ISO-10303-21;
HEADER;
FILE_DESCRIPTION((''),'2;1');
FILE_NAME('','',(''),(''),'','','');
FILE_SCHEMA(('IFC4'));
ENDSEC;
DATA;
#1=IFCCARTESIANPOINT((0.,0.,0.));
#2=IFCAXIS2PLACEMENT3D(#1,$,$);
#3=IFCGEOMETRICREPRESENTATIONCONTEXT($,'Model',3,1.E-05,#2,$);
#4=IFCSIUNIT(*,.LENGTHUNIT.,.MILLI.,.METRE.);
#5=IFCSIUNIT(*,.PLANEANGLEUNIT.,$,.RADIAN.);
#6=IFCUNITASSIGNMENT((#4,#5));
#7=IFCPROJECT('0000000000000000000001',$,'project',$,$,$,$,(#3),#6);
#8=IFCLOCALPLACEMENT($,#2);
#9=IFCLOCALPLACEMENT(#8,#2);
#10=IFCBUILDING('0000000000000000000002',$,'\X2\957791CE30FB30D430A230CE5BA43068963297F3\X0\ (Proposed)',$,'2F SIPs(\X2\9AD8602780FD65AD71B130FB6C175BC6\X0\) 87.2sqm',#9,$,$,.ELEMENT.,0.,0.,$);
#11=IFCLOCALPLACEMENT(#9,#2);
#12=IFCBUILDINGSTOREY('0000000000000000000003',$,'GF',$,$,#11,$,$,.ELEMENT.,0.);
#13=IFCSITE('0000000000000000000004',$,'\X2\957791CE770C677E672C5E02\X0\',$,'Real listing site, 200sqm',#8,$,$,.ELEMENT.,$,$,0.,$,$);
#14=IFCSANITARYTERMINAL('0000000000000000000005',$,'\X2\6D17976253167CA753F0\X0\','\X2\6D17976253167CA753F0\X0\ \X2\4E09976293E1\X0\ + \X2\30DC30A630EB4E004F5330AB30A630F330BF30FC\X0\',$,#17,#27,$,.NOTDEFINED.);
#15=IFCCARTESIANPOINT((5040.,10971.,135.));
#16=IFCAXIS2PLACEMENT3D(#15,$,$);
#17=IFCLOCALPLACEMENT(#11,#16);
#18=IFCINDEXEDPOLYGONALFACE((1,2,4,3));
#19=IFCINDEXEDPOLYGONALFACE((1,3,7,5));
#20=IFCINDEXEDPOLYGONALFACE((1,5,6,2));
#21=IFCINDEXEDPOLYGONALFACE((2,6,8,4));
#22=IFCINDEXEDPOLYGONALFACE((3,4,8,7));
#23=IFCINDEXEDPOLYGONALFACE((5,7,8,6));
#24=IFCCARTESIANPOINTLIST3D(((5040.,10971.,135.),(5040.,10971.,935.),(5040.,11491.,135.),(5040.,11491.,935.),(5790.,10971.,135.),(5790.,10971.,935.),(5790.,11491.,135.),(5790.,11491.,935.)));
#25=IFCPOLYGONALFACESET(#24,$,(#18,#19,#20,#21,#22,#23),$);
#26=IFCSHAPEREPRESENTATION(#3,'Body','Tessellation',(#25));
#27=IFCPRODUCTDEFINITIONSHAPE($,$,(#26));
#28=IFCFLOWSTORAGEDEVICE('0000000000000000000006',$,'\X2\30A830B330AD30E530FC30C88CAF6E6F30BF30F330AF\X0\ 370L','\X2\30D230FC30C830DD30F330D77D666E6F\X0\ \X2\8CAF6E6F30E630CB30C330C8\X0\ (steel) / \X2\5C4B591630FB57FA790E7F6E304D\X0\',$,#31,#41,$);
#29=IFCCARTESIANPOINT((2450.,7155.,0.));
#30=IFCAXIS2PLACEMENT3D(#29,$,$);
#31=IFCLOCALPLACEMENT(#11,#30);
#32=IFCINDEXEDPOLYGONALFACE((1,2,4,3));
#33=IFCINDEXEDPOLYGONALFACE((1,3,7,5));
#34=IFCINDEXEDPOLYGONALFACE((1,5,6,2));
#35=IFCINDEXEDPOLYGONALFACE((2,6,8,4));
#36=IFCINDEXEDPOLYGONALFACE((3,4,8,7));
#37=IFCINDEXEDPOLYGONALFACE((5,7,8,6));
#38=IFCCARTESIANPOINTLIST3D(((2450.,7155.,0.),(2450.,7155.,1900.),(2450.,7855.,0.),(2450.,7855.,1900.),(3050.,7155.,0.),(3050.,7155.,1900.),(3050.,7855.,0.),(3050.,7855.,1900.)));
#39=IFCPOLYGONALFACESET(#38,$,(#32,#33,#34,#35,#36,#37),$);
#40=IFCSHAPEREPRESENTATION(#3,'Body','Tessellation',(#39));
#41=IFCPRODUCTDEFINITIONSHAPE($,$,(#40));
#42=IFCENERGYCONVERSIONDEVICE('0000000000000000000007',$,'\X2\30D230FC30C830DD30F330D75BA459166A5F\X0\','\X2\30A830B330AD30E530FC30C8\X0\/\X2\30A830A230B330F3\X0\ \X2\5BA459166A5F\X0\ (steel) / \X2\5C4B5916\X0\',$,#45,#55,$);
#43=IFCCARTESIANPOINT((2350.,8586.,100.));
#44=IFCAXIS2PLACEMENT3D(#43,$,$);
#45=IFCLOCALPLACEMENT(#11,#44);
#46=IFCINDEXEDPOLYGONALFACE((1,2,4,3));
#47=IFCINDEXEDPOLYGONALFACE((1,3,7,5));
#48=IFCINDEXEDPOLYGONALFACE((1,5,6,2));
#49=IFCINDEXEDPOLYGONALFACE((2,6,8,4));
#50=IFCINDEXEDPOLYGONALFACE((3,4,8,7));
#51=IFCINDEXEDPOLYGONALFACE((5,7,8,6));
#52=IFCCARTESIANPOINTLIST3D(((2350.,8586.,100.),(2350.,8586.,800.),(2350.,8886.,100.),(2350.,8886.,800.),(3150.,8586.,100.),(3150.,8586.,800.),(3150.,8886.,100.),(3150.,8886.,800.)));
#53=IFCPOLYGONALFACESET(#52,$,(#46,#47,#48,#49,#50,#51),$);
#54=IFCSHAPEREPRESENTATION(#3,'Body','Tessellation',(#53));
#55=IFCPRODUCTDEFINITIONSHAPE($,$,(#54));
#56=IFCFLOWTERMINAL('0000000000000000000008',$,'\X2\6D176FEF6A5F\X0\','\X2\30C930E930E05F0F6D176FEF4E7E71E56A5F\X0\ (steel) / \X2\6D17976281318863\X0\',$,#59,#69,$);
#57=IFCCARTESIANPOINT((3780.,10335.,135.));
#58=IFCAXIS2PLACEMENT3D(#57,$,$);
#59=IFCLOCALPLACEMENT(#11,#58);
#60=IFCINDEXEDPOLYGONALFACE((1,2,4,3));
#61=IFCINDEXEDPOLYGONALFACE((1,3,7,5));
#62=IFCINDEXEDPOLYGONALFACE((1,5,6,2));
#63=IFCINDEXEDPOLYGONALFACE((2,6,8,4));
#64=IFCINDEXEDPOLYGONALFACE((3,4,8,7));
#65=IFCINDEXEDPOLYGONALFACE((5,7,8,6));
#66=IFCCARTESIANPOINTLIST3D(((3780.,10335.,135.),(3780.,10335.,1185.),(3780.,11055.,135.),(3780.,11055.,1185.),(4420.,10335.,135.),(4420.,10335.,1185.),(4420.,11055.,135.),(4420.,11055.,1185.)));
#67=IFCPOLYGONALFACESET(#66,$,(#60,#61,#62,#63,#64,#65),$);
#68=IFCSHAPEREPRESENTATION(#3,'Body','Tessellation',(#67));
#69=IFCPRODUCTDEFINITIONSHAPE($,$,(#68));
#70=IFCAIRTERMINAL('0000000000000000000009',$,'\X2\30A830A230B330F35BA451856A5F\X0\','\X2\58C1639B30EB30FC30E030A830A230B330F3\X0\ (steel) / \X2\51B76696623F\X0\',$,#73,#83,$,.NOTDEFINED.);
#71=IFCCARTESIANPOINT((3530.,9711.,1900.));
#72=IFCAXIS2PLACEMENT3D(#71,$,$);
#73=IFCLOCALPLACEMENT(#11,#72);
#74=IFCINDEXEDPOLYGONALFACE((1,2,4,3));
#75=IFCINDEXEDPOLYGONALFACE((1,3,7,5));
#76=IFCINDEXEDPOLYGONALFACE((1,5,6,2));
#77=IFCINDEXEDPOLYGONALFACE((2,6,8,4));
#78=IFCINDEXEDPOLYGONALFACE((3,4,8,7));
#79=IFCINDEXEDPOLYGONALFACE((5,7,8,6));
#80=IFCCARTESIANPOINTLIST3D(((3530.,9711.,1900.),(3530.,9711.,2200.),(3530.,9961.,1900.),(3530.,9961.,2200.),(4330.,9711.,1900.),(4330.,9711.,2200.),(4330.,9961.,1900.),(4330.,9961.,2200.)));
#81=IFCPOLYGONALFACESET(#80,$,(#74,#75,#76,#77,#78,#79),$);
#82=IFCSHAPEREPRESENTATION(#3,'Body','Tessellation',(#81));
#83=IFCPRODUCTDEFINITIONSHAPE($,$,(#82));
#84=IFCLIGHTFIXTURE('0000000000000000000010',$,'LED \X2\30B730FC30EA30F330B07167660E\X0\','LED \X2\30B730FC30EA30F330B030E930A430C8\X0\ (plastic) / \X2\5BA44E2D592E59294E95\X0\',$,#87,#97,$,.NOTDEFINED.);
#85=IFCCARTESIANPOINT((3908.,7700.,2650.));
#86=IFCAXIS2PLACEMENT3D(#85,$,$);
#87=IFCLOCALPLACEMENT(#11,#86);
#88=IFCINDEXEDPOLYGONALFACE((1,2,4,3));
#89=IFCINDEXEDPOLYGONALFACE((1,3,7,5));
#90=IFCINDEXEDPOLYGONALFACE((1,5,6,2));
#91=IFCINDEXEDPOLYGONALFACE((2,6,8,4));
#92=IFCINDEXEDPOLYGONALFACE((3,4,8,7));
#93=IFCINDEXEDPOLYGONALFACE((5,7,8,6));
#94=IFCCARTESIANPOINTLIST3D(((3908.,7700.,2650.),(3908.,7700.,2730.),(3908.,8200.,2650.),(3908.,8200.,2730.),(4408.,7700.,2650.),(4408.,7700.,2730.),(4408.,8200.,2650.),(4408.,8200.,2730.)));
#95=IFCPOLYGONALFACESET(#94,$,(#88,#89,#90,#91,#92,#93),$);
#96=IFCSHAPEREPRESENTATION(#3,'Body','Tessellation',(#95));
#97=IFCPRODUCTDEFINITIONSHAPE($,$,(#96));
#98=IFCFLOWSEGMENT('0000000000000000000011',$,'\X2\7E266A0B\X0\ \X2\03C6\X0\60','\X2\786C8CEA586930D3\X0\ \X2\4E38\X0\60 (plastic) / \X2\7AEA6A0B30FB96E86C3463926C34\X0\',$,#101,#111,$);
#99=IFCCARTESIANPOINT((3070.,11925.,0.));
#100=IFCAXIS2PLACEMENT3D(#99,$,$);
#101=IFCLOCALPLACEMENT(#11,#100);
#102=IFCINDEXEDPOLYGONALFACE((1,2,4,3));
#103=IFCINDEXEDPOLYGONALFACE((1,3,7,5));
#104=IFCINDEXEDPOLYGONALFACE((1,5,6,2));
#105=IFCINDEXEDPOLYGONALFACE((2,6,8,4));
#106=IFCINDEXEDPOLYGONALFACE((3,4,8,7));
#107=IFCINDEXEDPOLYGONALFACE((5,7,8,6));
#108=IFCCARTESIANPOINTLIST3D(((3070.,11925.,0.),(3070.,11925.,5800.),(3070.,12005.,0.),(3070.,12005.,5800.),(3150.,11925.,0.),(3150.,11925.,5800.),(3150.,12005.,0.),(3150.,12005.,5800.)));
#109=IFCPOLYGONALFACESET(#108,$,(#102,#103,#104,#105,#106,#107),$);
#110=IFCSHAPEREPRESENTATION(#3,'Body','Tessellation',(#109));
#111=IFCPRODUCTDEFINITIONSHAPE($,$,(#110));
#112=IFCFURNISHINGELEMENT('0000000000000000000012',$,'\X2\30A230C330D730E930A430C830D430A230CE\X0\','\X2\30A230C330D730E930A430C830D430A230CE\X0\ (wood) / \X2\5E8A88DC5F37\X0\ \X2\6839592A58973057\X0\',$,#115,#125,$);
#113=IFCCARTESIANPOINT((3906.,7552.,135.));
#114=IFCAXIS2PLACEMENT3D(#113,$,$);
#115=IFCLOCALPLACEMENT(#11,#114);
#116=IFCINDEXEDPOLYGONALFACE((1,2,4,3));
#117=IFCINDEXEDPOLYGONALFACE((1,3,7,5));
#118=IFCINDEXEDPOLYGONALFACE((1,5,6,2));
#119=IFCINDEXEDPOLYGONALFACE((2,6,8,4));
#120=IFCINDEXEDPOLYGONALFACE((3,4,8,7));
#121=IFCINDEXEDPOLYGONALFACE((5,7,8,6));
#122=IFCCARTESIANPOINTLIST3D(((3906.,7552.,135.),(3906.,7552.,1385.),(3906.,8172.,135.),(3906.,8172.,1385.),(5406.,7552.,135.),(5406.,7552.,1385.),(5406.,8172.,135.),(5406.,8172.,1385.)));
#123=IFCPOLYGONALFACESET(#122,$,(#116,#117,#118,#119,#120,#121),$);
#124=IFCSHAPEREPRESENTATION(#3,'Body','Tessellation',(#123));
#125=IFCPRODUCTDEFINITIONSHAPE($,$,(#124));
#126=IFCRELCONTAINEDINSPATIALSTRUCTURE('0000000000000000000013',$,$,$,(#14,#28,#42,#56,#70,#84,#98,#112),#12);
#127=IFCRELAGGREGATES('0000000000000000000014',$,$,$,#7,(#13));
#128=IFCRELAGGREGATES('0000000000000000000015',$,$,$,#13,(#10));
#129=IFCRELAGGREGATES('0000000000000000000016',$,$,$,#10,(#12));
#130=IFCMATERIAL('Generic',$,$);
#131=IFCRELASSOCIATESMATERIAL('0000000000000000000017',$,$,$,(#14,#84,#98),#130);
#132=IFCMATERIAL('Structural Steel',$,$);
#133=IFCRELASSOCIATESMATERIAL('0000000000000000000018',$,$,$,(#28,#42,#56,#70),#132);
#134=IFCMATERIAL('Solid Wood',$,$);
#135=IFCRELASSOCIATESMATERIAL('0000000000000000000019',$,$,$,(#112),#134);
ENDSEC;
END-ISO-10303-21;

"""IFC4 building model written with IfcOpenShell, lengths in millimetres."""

from ifc_helpers import new_model, si_unit, frame, frame_2d, origin, place, context, project, spatial, rectangle, extrude, material, element, save


model = new_model("IFC4")

# Units and contexts
model_context = context("Model", 3, precision=1e-05, world=origin())
ifc_project = project(units=[si_unit("LENGTHUNIT", "METRE", prefix="MILLI"), si_unit("PLANEANGLEUNIT", "RADIAN")], contexts=[model_context])

# Site, building, storey
site_placement = place(None, origin())
site = spatial("IfcSite", under=ifc_project, at=site_placement, Name="長野県松本市", ObjectType="Real listing site, 200sqm", CompositionType="ELEMENT", RefElevation=0.0)
building_placement = place(site_placement, origin())
building = spatial("IfcBuilding", under=site, at=building_placement, Name="長野・ピアノ室と防音 (Proposed)", ObjectType="2F SIPs(高性能断熱・気密) 87.2sqm", CompositionType="ELEMENT", ElevationOfRefHeight=0.0, ElevationOfTerrain=0.0)
storey_placement = place(building_placement, origin())
storey = spatial("IfcBuildingStorey", under=building, at=storey_placement, Name="GF", CompositionType="ELEMENT", Elevation=0.0)

# Shared definitions
ifc_material_1 = material(Name="Solid Wood")

# Shared definitions
ifc_material_2 = material(Name="Generic")

# Sanitary terminal
sanitary_terminal_1_placement = place(storey_placement, frame((5040.0, 10971.0, 135.0)))
element("IfcSanitaryTerminal", 1, at=sanitary_terminal_1_placement, inside=storey, material=ifc_material_2, Name="洗面化粧台", Description="洗面化粧台 三面鏡 + ボウル一体カウンター", PredefinedType="NOTDEFINED", context=model_context, shape_type="SweptSolid", body=[
    extrude(rectangle(XDim=750.0, YDim=520.0, at=frame_2d((375.0, 260.0))), frame((5040.0, 10971.0, 135.0)), (0.0, 0.0, 1.0), 800.0),
])

# Flow storage device
ifc_material_3 = material(Name="Structural Steel")
flow_storage_device_placement = place(storey_placement, frame((2450.0, 7155.0, 0.0)))
element("IfcFlowStorageDevice", 2, at=flow_storage_device_placement, inside=storey, material=ifc_material_3, Name="エコキュート貯湯タンク 370L", Description="ヒートポンプ給湯 貯湯ユニット (steel) / 屋外・基礎置き", context=model_context, shape_type="SweptSolid", body=[
    extrude(rectangle(XDim=600.0, YDim=700.0, at=frame_2d((300.0, 350.0))), frame((2450.0, 7155.0, 0.0)), (0.0, 0.0, 1.0), 1900.0),
])

# Energy conversion device
energy_conversion_device_placement = place(storey_placement, frame((2350.0, 8586.0, 100.0)))
element("IfcEnergyConversionDevice", 3, at=energy_conversion_device_placement, inside=storey, material=ifc_material_3, Name="ヒートポンプ室外機", Description="エコキュート/エアコン 室外機 (steel) / 屋外", context=model_context, shape_type="SweptSolid", body=[
    extrude(rectangle(XDim=800.0, YDim=300.0, at=frame_2d((400.0, 150.0))), frame((2350.0, 8586.0, 100.0)), (0.0, 0.0, 1.0), 700.0),
])

# Flow terminal
flow_terminal_placement = place(storey_placement, frame((3780.0, 10335.0, 135.0)))
element("IfcFlowTerminal", 4, at=flow_terminal_placement, inside=storey, material=ifc_material_3, Name="洗濯機", Description="ドラム式洗濯乾燥機 (steel) / 洗面脱衣", context=model_context, shape_type="SweptSolid", body=[
    extrude(rectangle(XDim=640.0, YDim=720.0, at=frame_2d((320.0, 360.0))), frame((3780.0, 10335.0, 135.0)), (0.0, 0.0, 1.0), 1050.0),
])

# Air terminal
air_terminal_placement = place(storey_placement, frame((3530.0, 9711.0, 1900.0)))
element("IfcAirTerminal", 5, at=air_terminal_placement, inside=storey, material=ifc_material_3, Name="エアコン室内機", Description="壁掛ルームエアコン (steel) / 冷暖房", PredefinedType="NOTDEFINED", context=model_context, shape_type="SweptSolid", body=[
    extrude(rectangle(XDim=800.0, YDim=250.0, at=frame_2d((400.0, 125.0))), frame((3530.0, 9711.0, 1900.0)), (0.0, 0.0, 1.0), 300.0),
])

# Light fixture
light_fixture_placement = place(storey_placement, frame((3908.0, 7700.0, 2650.0)))
element("IfcLightFixture", 6, at=light_fixture_placement, inside=storey, material=ifc_material_2, Name="LED シーリング照明", Description="LED シーリングライト (plastic) / 室中央天井", PredefinedType="NOTDEFINED", context=model_context, shape_type="SweptSolid", body=[
    extrude(rectangle(XDim=500.0, YDim=500.0, at=frame_2d((250.0, 250.0))), frame((3908.0, 7700.0, 2650.0)), (0.0, 0.0, 1.0), 80.0),
])

# Flow segment
flow_segment_placement = place(storey_placement, frame((3070.0, 11925.0, 0.0)))
element("IfcFlowSegment", 7, at=flow_segment_placement, inside=storey, material=ifc_material_2, Name="縦樋 φ60", Description="硬質塩ビ 丸60 (plastic) / 竪樋・雨水排水", context=model_context, shape_type="SweptSolid", body=[
    extrude(rectangle(XDim=80.0, YDim=80.0, at=frame_2d((40.0, 40.0))), frame((3070.0, 11925.0, 0.0)), (0.0, 0.0, 1.0), 5800.0),
])

# Furnishing element
furnishing_placement = place(storey_placement, frame((3906.0, 7552.0, 135.0)))
element("IfcFurnishingElement", 8, at=furnishing_placement, inside=storey, material=ifc_material_1, Name="アップライトピアノ", Description="アップライトピアノ (wood) / 床補強 根太増し", context=model_context, shape_type="SweptSolid", body=[
    extrude(rectangle(XDim=1500.0, YDim=620.0, at=frame_2d((750.0, 310.0))), frame((3906.0, 7552.0, 135.0)), (0.0, 0.0, 1.0), 1250.0),
])

save(model, "model.ifc")
